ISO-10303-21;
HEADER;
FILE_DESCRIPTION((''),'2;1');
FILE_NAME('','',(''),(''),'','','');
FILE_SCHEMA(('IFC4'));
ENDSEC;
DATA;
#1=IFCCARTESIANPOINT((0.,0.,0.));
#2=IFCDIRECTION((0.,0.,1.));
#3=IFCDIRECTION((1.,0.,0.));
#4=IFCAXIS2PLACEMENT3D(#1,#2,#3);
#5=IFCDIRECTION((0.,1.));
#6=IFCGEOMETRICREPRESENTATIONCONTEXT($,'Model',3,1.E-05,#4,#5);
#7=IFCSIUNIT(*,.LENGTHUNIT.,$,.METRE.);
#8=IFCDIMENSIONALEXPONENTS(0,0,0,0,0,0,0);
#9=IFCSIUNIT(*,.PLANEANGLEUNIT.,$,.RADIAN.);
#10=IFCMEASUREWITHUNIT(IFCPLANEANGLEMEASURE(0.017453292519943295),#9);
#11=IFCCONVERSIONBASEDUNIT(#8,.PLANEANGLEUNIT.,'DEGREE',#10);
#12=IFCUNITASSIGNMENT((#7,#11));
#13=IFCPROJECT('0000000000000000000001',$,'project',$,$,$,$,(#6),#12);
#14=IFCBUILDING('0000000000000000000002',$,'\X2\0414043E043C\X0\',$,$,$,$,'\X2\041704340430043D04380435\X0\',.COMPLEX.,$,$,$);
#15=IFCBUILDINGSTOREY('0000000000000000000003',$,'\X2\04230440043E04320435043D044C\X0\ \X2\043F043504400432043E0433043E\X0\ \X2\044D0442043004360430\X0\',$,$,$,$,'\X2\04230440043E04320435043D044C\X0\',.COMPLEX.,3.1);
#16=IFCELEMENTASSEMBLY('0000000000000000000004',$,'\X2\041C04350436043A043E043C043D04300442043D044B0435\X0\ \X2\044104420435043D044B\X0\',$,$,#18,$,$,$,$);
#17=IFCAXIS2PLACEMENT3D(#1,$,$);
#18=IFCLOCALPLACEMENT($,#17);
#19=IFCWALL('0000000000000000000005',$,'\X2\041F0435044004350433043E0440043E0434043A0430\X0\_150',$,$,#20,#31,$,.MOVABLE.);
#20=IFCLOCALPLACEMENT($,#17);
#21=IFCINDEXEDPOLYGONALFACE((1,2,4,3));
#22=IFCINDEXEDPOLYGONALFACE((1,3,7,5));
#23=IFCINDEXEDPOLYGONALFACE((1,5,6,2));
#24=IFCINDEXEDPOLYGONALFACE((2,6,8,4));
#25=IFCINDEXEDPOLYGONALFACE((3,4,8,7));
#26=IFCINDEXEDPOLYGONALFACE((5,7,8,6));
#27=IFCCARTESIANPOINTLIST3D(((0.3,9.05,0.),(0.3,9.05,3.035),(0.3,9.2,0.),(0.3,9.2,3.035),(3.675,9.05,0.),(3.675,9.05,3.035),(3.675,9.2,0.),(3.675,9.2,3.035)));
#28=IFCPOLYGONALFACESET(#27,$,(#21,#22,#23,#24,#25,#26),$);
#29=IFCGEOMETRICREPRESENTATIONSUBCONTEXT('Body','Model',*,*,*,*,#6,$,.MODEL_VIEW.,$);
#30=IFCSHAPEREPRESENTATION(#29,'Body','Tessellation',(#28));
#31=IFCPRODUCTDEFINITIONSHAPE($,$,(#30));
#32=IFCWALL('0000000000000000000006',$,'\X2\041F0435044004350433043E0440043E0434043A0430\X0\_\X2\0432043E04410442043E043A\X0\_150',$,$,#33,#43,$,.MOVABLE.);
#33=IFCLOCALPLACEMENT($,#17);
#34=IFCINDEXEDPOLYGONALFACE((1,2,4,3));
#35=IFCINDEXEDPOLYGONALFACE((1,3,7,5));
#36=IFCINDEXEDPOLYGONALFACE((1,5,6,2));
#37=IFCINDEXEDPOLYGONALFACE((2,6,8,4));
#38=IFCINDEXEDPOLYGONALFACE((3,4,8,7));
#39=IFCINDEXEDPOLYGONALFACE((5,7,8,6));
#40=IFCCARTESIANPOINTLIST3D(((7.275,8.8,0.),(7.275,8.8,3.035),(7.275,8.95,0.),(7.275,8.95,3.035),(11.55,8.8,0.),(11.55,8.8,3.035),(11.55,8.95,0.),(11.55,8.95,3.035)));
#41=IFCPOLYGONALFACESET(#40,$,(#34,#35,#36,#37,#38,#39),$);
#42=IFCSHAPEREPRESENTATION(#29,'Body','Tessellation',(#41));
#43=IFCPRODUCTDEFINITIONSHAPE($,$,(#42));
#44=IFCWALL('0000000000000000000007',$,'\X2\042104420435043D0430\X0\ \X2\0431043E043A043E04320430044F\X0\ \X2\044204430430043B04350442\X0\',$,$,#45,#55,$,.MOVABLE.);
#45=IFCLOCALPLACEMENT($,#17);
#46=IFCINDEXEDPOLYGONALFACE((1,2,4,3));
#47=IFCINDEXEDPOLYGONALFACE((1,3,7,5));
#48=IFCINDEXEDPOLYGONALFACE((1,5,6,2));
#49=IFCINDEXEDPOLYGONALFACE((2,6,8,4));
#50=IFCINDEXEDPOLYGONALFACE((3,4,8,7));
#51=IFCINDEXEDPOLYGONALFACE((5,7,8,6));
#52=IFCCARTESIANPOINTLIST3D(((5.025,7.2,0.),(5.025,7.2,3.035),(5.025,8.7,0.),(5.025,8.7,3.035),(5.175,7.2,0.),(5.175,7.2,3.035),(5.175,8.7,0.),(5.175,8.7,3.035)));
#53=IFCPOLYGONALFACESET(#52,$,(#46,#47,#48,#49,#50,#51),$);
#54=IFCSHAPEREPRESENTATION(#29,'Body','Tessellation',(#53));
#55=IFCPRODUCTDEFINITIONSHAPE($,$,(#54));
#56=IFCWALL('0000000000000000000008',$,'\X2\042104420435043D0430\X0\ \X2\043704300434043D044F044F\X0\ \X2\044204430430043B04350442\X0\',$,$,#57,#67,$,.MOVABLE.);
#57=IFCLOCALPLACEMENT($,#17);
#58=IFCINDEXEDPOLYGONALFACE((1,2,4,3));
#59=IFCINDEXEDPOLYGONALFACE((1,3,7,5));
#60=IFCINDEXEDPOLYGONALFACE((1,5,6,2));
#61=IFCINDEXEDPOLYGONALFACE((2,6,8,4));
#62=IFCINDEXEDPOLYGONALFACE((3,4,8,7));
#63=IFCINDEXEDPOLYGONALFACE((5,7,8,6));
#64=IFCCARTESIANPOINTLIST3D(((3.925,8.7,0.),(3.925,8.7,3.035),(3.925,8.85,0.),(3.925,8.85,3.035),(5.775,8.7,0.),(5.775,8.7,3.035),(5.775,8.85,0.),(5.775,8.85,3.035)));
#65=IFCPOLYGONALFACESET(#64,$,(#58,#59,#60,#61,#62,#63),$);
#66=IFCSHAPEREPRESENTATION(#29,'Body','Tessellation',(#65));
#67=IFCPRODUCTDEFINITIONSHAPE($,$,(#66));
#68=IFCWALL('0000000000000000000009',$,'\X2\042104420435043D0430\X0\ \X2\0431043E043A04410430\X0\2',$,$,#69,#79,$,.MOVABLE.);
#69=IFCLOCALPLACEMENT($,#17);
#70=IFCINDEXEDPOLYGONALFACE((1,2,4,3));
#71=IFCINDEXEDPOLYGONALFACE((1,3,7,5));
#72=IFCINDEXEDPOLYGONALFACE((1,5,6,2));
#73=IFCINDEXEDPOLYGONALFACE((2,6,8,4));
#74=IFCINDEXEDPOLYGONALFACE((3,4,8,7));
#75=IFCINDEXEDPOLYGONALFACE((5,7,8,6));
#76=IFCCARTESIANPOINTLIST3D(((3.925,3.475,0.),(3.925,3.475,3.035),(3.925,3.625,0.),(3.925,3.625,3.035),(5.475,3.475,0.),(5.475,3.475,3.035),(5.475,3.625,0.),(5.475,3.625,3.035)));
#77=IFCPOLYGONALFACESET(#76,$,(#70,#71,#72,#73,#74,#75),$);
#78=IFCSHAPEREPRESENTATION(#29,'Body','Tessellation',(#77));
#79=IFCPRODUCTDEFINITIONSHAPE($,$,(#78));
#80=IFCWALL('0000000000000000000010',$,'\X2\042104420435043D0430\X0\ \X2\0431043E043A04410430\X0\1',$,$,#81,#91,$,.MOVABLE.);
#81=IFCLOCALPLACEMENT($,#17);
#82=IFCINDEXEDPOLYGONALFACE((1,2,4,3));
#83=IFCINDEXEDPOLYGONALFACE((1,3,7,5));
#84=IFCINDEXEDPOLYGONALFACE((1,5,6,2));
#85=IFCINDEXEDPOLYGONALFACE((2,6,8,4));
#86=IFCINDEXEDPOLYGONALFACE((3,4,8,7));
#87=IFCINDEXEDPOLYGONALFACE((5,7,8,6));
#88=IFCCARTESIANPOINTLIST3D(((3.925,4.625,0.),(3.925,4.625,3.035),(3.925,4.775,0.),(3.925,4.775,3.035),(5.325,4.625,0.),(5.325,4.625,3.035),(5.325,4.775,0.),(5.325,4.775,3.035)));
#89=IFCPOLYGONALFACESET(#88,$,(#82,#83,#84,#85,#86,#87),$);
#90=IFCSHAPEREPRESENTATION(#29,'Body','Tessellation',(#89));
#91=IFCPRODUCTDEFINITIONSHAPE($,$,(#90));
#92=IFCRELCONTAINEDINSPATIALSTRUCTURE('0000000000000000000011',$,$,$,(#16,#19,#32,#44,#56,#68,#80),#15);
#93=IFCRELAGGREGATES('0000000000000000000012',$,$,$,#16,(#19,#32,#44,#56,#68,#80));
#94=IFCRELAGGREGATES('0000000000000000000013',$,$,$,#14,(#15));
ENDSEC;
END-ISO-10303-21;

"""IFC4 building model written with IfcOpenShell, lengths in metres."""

from ifc_helpers import new_model, entity, si_unit, converted_unit, direction, frame, frame_2d, origin_with_axes, origin_2d_with_axis, place, context, subcontext, project, spatial, rectangle, extrude, element, aggregate, save


model = new_model("IFC4")

# Units and contexts
model_context = context("Model", 3, precision=1e-05, world=origin_with_axes(), true_north=direction((0.0, 1.0)))
body_context = subcontext(model_context, "Body", "Model", "MODEL_VIEW")
ifc_project = project(units=[si_unit("LENGTHUNIT", "METRE"), converted_unit("PLANEANGLEUNIT", "DEGREE", entity("IfcPlaneAngleMeasure", 0.017453292519943295), si_unit("PLANEANGLEUNIT", "RADIAN"), dimensions=[0, 0, 0, 0, 0, 0, 0])], contexts=[model_context])

# Building, storey
building = spatial("IfcBuilding", Name="Дом", LongName="Здание", CompositionType="COMPLEX")
storey = spatial("IfcBuildingStorey", under=building, Name="Уровень первого этажа", LongName="Уровень", CompositionType="COMPLEX", Elevation=3.1)

# Element assembly, walls
assembly = element("IfcElementAssembly", 1, inside=storey, Name="Межкомнатные стены")
placement = place(None, origin_with_axes())
wall_1 = element("IfcWall", 2, at=placement, inside=storey, Name="Перегородка_150", PredefinedType="MOVABLE", context=body_context, shape_type="SweptSolid", body=[
    extrude(rectangle(XDim=3.375, YDim=0.15, at=origin_2d_with_axis()), frame((1.9875, 9.125, 0.0), z_axis=(0.0, 0.0, 1.0), x_axis=(1.0, 0.0, 0.0)), (0.0, 0.0, 1.0), 3.035),
])
wall_2 = element("IfcWall", 3, at=placement, inside=storey, Name="Перегородка_восток_150", PredefinedType="MOVABLE", context=body_context, shape_type="SweptSolid", body=[
    extrude(rectangle(XDim=4.275, YDim=0.15, at=frame_2d((0.0, 0.0), x_axis=(1.0, 0.0))), frame((9.4125, 8.875, 0.0), z_axis=(0.0, 0.0, 1.0), x_axis=(1.0, 0.0, 0.0)), (0.0, 0.0, 1.0), 3.035),
])
wall_3 = element("IfcWall", 4, at=placement, inside=storey, Name="Стена боковая туалет", PredefinedType="MOVABLE", context=body_context, shape_type="SweptSolid", body=[
    extrude(rectangle(XDim=1.5, YDim=0.15, at=frame_2d((0.0, 0.0), x_axis=(0.0, 1.0))), frame((5.1, 7.95, 0.0), z_axis=(0.0, 0.0, 1.0), x_axis=(1.0, 0.0, 0.0)), (0.0, 0.0, 1.0), 3.035),
])
wall_4 = element("IfcWall", 5, at=placement, inside=storey, Name="Стена задняя туалет", PredefinedType="MOVABLE", context=body_context, shape_type="SweptSolid", body=[
    extrude(rectangle(XDim=1.85, YDim=0.15, at=frame_2d((0.0, 0.0), x_axis=(1.0, 0.0))), frame((4.85, 8.775, 0.0), z_axis=(0.0, 0.0, 1.0), x_axis=(1.0, 0.0, 0.0)), (0.0, 0.0, 1.0), 3.035),
])
wall_5 = element("IfcWall", 6, at=placement, inside=storey, Name="Стена бокса2", PredefinedType="MOVABLE", context=body_context, shape_type="SweptSolid", body=[
    extrude(rectangle(XDim=1.55, YDim=0.15, at=frame_2d((0.0, 0.0), x_axis=(1.0, 0.0))), frame((4.7, 3.55, 0.0), z_axis=(0.0, 0.0, 1.0), x_axis=(1.0, 0.0, 0.0)), (0.0, 0.0, 1.0), 3.035),
])
wall_6 = element("IfcWall", 7, at=placement, inside=storey, Name="Стена бокса1", PredefinedType="MOVABLE", context=body_context, shape_type="SweptSolid", body=[
    extrude(rectangle(XDim=1.4, YDim=0.15, at=origin_2d_with_axis()), frame((4.625, 4.7, 0.0), z_axis=(0.0, 0.0, 1.0), x_axis=(1.0, 0.0, 0.0)), (0.0, 0.0, 1.0), 3.035),
])
aggregate(assembly, [wall_1, wall_2, wall_3, wall_4, wall_5, wall_6])

save(model, "model.ifc")
